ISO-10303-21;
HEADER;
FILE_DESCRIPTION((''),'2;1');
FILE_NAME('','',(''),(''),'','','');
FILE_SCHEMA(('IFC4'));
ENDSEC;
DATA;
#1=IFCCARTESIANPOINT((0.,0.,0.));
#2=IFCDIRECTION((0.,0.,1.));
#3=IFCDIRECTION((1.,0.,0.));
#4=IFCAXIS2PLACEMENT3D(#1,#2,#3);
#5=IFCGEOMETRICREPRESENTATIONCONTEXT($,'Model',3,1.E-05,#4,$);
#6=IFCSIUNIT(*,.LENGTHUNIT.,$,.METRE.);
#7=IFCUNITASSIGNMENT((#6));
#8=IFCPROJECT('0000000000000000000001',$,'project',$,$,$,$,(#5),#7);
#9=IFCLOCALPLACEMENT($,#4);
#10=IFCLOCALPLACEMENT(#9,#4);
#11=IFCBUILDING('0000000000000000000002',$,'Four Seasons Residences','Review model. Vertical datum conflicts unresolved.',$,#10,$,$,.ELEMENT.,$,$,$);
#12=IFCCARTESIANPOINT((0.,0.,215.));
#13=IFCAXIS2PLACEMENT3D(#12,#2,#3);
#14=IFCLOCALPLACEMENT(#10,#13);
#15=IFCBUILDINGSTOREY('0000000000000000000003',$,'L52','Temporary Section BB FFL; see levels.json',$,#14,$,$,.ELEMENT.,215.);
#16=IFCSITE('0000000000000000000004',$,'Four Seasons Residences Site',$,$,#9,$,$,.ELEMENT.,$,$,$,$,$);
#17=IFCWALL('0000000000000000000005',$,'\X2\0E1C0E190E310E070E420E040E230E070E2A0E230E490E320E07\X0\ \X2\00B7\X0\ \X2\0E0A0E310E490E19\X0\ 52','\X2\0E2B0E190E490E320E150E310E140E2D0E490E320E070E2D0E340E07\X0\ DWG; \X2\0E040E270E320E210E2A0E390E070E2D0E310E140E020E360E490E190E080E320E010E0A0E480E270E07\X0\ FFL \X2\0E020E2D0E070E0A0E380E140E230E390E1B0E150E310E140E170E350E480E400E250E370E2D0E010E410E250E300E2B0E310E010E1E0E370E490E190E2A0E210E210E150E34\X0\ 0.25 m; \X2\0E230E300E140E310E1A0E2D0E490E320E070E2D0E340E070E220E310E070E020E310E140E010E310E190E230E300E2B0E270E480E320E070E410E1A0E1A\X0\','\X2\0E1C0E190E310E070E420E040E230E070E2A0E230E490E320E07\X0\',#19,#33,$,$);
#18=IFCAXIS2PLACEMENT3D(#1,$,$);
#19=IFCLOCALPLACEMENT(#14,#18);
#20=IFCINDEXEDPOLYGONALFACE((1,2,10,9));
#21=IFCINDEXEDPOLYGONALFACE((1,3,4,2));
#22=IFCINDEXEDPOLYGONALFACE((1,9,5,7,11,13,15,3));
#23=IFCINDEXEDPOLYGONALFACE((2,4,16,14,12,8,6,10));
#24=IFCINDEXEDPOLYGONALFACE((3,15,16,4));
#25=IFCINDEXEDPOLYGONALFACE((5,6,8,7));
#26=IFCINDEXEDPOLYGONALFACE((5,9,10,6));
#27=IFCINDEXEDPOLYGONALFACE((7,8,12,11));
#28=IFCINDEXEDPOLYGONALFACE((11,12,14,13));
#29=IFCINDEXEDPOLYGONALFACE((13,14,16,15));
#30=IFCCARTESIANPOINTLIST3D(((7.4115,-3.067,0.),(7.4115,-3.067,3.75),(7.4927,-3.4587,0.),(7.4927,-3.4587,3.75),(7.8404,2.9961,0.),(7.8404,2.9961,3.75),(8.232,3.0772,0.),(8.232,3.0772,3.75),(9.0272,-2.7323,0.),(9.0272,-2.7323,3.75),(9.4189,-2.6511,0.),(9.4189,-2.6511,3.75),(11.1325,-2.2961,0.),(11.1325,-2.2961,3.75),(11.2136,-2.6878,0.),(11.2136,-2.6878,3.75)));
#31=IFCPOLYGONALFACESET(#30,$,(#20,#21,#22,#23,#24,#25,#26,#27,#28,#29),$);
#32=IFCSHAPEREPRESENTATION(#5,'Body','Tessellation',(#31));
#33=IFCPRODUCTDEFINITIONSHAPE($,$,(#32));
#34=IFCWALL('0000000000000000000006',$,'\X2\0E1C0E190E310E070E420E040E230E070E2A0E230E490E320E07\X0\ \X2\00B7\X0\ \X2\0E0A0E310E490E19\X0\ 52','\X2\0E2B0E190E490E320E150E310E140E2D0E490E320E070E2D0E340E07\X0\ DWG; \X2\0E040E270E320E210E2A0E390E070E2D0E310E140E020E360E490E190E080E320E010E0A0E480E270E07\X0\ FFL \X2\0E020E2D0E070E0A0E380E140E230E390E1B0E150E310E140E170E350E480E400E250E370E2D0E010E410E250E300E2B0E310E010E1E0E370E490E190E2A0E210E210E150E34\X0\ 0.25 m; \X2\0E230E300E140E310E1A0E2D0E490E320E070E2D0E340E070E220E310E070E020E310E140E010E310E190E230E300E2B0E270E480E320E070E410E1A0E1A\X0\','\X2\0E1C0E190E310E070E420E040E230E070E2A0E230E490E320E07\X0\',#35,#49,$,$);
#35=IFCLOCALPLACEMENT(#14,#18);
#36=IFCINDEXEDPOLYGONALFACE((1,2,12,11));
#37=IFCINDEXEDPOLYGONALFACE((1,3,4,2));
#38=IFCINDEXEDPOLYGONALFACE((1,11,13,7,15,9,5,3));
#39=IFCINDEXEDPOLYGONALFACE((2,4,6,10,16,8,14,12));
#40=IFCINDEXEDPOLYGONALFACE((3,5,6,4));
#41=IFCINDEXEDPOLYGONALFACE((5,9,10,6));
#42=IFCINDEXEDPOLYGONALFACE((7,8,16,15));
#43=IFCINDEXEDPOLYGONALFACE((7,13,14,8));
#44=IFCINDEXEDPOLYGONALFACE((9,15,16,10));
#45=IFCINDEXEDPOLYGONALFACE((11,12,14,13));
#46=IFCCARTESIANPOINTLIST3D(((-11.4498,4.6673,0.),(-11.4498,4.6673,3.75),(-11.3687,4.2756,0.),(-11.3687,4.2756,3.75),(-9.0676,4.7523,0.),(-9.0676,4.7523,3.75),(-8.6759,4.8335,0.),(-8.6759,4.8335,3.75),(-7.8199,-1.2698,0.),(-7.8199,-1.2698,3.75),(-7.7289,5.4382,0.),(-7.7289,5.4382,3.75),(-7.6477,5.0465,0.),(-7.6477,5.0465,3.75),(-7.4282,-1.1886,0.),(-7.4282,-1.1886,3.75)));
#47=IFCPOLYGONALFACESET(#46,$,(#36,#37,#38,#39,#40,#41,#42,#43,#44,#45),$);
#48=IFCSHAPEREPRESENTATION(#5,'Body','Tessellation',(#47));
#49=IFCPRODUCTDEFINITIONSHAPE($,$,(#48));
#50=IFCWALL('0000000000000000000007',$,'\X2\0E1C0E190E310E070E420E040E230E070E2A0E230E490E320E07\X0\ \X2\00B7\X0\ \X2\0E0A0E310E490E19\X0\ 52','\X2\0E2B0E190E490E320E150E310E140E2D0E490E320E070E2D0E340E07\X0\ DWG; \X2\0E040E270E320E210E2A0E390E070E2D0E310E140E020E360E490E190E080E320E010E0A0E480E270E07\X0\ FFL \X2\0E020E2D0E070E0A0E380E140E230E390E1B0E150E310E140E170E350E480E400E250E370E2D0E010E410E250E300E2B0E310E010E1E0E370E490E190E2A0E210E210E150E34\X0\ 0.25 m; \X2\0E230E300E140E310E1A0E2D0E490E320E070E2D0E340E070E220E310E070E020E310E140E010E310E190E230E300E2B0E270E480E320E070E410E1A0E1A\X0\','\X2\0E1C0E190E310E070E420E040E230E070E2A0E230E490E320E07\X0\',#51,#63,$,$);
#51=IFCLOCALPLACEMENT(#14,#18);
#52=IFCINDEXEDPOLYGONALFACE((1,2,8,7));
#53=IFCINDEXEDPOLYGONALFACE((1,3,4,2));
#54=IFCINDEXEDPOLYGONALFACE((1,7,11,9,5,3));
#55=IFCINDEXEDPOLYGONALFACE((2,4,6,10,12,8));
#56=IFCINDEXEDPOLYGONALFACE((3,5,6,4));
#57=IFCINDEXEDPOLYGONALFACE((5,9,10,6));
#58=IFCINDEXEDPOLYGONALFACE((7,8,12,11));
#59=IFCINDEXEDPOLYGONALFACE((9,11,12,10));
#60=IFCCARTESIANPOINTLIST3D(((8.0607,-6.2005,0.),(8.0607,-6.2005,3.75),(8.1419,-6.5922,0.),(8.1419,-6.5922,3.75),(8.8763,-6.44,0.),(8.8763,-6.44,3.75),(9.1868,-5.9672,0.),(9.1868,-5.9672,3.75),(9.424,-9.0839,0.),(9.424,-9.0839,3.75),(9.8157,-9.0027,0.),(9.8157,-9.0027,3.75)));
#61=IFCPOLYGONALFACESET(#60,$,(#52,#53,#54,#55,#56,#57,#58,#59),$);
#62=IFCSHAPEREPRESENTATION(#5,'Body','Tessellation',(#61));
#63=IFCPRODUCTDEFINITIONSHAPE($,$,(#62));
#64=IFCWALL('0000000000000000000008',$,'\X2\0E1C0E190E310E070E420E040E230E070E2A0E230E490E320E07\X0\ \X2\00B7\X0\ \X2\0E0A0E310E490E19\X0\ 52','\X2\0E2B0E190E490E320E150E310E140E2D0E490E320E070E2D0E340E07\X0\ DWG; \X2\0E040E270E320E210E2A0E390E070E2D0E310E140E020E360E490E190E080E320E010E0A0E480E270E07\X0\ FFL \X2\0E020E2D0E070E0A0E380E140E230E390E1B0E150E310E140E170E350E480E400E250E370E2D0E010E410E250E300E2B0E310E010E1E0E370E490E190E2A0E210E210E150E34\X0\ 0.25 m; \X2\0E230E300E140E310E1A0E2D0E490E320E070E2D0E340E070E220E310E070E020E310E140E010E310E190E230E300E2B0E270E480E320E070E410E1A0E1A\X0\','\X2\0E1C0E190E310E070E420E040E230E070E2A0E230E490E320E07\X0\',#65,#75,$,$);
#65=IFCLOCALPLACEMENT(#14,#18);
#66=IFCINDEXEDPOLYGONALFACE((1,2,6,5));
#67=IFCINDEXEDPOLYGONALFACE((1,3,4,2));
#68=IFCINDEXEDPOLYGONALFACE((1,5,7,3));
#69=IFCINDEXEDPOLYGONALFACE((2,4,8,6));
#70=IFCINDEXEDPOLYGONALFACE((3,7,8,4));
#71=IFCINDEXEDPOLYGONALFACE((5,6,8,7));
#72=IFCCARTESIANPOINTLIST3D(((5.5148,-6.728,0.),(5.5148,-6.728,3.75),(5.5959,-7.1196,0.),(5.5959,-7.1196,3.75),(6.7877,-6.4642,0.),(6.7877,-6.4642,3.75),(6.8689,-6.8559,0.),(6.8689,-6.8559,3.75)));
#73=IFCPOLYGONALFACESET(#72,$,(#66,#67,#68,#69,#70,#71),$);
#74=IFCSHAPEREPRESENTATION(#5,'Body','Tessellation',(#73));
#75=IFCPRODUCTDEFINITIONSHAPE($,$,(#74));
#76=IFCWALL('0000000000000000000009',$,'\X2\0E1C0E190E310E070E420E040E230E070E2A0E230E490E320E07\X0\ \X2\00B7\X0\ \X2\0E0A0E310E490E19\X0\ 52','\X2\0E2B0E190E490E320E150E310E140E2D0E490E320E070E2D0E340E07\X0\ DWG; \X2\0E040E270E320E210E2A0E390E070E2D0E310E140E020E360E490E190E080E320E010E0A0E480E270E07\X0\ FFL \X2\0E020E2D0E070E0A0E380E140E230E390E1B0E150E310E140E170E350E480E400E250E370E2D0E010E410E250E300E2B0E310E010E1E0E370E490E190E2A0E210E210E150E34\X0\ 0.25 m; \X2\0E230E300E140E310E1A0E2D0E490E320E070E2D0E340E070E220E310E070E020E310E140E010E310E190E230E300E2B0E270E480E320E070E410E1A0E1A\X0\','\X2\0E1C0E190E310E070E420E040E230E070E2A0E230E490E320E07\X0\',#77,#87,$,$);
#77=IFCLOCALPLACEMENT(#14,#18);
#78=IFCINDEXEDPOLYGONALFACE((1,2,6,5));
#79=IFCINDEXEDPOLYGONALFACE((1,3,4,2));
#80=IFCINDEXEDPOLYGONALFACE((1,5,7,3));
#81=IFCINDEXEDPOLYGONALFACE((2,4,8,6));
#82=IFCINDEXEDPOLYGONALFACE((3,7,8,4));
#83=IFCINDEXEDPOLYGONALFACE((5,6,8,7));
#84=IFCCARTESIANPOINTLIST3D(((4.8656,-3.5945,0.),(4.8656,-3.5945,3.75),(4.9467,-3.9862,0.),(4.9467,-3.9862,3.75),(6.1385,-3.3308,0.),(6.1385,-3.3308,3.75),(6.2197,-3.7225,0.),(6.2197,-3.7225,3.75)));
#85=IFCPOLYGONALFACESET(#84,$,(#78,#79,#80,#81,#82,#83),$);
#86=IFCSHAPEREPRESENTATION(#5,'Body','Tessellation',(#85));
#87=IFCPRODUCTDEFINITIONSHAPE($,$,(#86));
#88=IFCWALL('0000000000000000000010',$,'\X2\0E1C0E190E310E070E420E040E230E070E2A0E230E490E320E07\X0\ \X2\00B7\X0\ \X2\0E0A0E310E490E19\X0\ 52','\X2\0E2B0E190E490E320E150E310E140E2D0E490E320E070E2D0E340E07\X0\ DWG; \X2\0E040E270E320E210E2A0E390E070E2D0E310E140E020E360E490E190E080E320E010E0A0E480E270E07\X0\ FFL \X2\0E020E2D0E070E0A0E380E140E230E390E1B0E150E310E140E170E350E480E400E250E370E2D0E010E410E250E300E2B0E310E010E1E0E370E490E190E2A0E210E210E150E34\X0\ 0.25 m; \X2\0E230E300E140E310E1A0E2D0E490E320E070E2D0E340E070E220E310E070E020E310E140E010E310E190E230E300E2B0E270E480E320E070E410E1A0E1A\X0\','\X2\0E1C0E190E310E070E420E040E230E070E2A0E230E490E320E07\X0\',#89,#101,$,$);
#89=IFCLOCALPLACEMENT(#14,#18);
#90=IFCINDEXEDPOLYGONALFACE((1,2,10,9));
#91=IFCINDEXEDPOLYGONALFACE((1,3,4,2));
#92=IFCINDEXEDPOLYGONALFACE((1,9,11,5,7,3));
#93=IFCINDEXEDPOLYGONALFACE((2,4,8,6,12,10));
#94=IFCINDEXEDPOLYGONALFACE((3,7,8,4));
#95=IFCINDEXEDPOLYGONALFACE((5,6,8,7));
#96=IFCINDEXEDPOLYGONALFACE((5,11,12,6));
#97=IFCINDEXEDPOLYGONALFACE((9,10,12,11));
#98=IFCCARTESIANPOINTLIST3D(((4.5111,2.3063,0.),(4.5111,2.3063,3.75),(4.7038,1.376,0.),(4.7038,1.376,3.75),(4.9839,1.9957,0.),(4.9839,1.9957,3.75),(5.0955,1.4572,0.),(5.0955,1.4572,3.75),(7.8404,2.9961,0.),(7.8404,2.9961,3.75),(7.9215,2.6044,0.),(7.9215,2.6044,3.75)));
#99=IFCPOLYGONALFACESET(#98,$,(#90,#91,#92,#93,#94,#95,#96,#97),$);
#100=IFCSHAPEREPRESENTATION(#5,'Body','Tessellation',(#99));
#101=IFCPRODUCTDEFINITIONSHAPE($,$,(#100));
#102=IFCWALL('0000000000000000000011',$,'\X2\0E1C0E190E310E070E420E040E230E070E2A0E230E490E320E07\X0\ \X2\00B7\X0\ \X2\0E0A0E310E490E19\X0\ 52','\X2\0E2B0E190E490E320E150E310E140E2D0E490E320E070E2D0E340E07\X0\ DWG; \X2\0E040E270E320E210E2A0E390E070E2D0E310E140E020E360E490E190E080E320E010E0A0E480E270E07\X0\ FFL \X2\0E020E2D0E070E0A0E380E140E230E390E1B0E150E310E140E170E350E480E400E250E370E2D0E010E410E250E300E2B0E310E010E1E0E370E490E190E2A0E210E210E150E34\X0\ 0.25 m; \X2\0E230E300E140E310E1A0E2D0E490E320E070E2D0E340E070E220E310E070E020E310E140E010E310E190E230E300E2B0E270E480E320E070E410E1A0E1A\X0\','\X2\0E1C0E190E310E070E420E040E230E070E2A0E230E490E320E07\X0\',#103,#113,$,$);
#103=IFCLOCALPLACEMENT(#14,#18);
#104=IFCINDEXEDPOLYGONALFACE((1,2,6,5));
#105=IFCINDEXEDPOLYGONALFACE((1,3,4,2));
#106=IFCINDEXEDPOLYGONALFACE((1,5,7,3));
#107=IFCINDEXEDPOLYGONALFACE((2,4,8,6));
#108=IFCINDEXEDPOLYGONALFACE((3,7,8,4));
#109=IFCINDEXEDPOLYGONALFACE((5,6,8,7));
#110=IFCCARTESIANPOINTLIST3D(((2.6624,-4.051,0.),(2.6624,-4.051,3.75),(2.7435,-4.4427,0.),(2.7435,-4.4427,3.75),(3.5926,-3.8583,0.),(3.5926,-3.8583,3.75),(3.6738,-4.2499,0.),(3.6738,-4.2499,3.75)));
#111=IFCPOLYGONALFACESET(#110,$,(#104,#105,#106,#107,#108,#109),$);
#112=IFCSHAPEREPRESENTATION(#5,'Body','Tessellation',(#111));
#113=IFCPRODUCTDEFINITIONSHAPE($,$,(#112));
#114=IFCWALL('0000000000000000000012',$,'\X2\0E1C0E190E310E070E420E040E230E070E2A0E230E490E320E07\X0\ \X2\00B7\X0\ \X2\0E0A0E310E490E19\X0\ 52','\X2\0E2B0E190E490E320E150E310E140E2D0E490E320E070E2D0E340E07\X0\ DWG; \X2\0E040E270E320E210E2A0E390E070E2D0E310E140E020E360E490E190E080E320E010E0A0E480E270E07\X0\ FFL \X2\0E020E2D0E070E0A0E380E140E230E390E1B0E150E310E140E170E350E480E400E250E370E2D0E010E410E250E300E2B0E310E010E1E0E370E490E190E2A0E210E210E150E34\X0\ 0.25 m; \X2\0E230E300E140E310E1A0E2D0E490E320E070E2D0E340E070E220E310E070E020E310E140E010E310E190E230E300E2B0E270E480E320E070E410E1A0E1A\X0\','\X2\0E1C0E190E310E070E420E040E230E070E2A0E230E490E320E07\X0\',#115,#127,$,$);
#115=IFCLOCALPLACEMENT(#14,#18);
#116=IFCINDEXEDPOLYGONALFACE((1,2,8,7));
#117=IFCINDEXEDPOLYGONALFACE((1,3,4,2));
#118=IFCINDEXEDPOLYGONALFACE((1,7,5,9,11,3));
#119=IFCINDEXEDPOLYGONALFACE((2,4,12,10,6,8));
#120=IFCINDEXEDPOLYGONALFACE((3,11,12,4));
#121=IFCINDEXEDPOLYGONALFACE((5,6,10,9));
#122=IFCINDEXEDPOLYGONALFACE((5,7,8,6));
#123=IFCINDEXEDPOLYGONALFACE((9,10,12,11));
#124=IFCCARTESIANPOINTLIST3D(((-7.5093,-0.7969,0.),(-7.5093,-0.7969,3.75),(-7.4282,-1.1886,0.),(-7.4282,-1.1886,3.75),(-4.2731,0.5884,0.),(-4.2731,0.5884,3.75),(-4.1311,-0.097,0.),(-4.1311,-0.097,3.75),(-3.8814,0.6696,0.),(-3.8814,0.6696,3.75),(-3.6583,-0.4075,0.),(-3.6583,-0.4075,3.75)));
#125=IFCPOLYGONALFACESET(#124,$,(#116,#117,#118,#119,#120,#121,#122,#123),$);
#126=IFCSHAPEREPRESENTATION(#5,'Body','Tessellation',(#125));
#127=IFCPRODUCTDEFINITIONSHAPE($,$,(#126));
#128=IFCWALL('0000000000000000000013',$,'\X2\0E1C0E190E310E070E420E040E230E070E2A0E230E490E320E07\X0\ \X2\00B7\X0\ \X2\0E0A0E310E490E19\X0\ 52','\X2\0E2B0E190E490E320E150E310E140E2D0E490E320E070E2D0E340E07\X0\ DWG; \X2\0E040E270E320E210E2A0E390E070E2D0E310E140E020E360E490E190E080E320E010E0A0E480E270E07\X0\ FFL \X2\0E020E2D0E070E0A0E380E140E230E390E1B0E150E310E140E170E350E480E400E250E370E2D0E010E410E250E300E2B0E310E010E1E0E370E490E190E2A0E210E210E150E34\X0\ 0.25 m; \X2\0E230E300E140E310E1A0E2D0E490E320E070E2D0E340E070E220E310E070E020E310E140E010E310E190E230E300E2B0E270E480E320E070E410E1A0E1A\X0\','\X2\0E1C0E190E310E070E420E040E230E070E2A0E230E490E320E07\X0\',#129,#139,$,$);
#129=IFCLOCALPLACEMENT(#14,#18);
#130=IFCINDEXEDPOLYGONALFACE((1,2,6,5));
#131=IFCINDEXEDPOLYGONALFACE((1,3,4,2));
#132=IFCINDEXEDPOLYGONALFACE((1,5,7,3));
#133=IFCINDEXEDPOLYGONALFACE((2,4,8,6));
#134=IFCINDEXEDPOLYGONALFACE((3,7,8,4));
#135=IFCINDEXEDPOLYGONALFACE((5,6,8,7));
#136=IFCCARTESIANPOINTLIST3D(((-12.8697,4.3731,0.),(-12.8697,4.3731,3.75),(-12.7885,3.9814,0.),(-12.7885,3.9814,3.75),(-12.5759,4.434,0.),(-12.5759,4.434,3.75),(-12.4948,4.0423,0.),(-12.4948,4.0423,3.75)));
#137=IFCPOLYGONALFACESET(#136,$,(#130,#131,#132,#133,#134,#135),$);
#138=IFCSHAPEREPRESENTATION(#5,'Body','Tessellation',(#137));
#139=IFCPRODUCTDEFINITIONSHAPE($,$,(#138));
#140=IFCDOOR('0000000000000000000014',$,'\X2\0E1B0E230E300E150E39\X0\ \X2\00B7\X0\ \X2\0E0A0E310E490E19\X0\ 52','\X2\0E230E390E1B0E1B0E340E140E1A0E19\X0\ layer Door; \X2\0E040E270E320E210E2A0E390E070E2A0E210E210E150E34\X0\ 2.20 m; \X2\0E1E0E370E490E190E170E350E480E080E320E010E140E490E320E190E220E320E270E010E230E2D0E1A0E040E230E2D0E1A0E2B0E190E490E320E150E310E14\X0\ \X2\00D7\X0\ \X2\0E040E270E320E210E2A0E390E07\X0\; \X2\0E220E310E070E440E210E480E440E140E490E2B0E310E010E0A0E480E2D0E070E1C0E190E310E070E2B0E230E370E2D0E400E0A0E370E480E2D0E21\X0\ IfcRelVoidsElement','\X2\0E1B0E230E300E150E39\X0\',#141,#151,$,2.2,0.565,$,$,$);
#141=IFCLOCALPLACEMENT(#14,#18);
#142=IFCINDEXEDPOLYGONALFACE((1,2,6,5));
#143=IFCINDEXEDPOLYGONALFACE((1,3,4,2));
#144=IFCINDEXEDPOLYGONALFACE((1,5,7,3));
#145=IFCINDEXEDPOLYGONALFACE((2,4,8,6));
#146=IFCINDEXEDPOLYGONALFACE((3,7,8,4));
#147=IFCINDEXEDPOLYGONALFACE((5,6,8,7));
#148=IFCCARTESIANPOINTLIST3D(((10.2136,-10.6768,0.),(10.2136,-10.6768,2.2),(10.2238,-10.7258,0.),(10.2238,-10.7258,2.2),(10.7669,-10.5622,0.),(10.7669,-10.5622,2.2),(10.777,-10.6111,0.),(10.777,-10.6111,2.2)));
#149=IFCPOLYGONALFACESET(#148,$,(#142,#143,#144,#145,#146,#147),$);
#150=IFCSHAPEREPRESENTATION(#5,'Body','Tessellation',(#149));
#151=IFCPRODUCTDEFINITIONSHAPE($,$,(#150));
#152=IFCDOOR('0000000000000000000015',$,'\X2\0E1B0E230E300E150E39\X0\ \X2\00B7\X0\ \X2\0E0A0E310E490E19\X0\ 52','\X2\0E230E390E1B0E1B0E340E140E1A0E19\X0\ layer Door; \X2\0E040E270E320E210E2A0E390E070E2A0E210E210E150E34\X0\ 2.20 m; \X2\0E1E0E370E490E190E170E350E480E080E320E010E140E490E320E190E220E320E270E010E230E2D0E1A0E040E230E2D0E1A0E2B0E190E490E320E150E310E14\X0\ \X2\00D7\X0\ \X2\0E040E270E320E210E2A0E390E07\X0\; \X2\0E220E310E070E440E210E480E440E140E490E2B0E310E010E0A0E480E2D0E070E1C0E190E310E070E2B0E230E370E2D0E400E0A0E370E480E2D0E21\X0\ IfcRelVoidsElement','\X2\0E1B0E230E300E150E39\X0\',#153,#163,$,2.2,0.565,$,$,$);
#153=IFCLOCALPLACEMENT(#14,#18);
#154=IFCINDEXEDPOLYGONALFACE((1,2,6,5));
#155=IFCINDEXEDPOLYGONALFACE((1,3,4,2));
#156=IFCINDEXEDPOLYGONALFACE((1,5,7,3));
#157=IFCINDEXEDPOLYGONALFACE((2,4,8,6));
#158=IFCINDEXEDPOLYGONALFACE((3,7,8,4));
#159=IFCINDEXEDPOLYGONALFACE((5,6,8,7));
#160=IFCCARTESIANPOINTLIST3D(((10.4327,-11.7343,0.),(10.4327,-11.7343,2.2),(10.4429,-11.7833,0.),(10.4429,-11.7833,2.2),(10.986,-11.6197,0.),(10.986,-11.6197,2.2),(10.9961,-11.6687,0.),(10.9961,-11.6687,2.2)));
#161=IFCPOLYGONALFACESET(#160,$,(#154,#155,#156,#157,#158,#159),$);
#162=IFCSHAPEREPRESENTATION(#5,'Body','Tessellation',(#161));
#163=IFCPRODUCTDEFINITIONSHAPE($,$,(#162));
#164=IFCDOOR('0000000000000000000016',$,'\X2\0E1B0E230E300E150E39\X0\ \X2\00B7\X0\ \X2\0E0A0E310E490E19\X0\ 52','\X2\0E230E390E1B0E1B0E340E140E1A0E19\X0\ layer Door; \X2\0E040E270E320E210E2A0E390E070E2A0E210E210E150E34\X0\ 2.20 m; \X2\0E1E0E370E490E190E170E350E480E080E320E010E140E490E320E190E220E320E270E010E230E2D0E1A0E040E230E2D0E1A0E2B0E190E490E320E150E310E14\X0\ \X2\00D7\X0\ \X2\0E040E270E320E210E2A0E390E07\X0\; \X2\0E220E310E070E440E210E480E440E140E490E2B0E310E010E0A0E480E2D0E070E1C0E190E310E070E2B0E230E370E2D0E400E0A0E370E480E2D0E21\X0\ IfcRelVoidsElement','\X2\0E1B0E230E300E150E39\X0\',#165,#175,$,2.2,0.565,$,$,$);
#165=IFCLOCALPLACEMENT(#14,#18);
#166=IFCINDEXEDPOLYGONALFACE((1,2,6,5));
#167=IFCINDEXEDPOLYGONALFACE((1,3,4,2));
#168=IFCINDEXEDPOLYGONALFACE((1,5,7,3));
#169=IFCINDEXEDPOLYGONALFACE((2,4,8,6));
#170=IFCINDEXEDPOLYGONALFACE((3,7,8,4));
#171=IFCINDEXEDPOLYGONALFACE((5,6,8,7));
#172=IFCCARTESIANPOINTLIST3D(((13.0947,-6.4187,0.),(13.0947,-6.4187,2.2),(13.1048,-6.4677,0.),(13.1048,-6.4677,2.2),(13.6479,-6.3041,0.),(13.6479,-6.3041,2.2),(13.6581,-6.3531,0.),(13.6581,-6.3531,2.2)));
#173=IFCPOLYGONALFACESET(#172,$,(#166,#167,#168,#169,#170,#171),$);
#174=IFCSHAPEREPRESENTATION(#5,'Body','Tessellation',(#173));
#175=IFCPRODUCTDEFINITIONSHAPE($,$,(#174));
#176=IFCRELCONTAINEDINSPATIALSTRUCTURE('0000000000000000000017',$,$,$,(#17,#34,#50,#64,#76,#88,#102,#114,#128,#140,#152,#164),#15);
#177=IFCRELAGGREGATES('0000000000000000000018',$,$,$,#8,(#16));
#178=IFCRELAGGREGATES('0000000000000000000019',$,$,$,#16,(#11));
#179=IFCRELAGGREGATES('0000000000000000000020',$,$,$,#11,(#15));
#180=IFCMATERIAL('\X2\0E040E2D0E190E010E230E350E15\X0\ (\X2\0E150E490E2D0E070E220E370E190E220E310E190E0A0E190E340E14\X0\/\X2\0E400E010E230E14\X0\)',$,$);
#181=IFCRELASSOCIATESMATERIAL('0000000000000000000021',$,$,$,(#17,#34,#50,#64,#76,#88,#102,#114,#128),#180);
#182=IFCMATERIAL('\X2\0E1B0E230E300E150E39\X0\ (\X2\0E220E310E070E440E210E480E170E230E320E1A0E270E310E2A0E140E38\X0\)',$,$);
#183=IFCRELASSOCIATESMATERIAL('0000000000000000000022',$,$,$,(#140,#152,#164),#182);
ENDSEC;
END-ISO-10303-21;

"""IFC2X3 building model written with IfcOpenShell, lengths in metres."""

from ifc_helpers import new_model, si_unit, frame, origin_with_axes, place, context, project, spatial, polyline, outline, extrude, material, element, save


model = new_model("IFC2X3")

# Units and contexts
model_context = context("Model", 3, precision=1e-05, world=origin_with_axes())
ifc_project = project(units=[si_unit("LENGTHUNIT", "METRE")], contexts=[model_context])

# Site, building, storey
site_placement = place(None, origin_with_axes())
site = spatial("IfcSite", under=ifc_project, at=site_placement, Name="Four Seasons Residences Site", CompositionType="ELEMENT")
building_placement = place(site_placement, origin_with_axes())
building = spatial("IfcBuilding", under=site, at=building_placement, Name="Four Seasons Residences", Description="Review model. Vertical datum conflicts unresolved.", CompositionType="ELEMENT")
storey_placement = place(building_placement, frame((0.0, 0.0, 215.0), z_axis=(0.0, 0.0, 1.0), x_axis=(1.0, 0.0, 0.0)))
storey = spatial("IfcBuildingStorey", under=building, at=storey_placement, Name="L52", Description="Temporary Section BB FFL; see levels.json", CompositionType="ELEMENT", Elevation=215.0)

# Shared definitions
ifc_material_1 = material(Name="คอนกรีต (ต้องยืนยันชนิด/เกรด)")

# Walls
wall_1_placement = place(storey_placement, origin_with_axes())
element("IfcWall", 1, at=wall_1_placement, inside=storey, material=ifc_material_1, Name="ผนังโครงสร้าง · ชั้น 52", Description="หน้าตัดอ้างอิง DWG; ความสูงอัดขึ้นจากช่วง FFL ของชุดรูปตัดที่เลือกและหักพื้นสมมติ 0.25 m; ระดับอ้างอิงยังขัดกันระหว่างแบบ", ObjectType="ผนังโครงสร้าง", context=model_context, shape_type="SweptSolid", body=[
    extrude(outline(polyline([(7.4115, -3.067), (7.4927, -3.4587), (11.2136, -2.6878), (11.1325, -2.2961), (9.4189, -2.6511), (8.232, 3.0772), (7.8404, 2.9961), (9.0272, -2.7323), (7.4115, -3.067)])), origin_with_axes(), (0.0, 0.0, 1.0), 3.75),
])
wall_2_placement = place(storey_placement, origin_with_axes())
element("IfcWall", 2, at=wall_2_placement, inside=storey, material=ifc_material_1, Name="ผนังโครงสร้าง · ชั้น 52", Description="หน้าตัดอ้างอิง DWG; ความสูงอัดขึ้นจากช่วง FFL ของชุดรูปตัดที่เลือกและหักพื้นสมมติ 0.25 m; ระดับอ้างอิงยังขัดกันระหว่างแบบ", ObjectType="ผนังโครงสร้าง", context=model_context, shape_type="SweptSolid", body=[
    extrude(outline(polyline([(-7.4282, -1.1886), (-8.6759, 4.8335), (-7.6477, 5.0465), (-7.7289, 5.4382), (-11.4498, 4.6673), (-11.3687, 4.2756), (-9.0676, 4.7523), (-7.8199, -1.2698), (-7.4282, -1.1886)])), origin_with_axes(), (0.0, 0.0, 1.0), 3.75),
])
wall_3_placement = place(storey_placement, origin_with_axes())
element("IfcWall", 3, at=wall_3_placement, inside=storey, material=ifc_material_1, Name="ผนังโครงสร้าง · ชั้น 52", Description="หน้าตัดอ้างอิง DWG; ความสูงอัดขึ้นจากช่วง FFL ของชุดรูปตัดที่เลือกและหักพื้นสมมติ 0.25 m; ระดับอ้างอิงยังขัดกันระหว่างแบบ", ObjectType="ผนังโครงสร้าง", context=model_context, shape_type="SweptSolid", body=[
    extrude(outline(polyline([(9.8157, -9.0027), (9.1868, -5.9672), (8.0607, -6.2005), (8.1419, -6.5922), (8.8763, -6.44), (9.424, -9.0839), (9.8157, -9.0027)])), origin_with_axes(), (0.0, 0.0, 1.0), 3.75),
])
wall_4_placement = place(storey_placement, origin_with_axes())
element("IfcWall", 4, at=wall_4_placement, inside=storey, material=ifc_material_1, Name="ผนังโครงสร้าง · ชั้น 52", Description="หน้าตัดอ้างอิง DWG; ความสูงอัดขึ้นจากช่วง FFL ของชุดรูปตัดที่เลือกและหักพื้นสมมติ 0.25 m; ระดับอ้างอิงยังขัดกันระหว่างแบบ", ObjectType="ผนังโครงสร้าง", context=model_context, shape_type="SweptSolid", body=[
    extrude(outline(polyline([(6.7877, -6.4642), (6.8689, -6.8559), (5.5959, -7.1196), (5.5148, -6.728), (6.7877, -6.4642)])), origin_with_axes(), (0.0, 0.0, 1.0), 3.75),
])
wall_5_placement = place(storey_placement, origin_with_axes())
element("IfcWall", 5, at=wall_5_placement, inside=storey, material=ifc_material_1, Name="ผนังโครงสร้าง · ชั้น 52", Description="หน้าตัดอ้างอิง DWG; ความสูงอัดขึ้นจากช่วง FFL ของชุดรูปตัดที่เลือกและหักพื้นสมมติ 0.25 m; ระดับอ้างอิงยังขัดกันระหว่างแบบ", ObjectType="ผนังโครงสร้าง", context=model_context, shape_type="SweptSolid", body=[
    extrude(outline(polyline([(4.9467, -3.9862), (4.8656, -3.5945), (6.1385, -3.3308), (6.2197, -3.7225), (4.9467, -3.9862)])), origin_with_axes(), (0.0, 0.0, 1.0), 3.75),
])
wall_6_placement = place(storey_placement, origin_with_axes())
element("IfcWall", 6, at=wall_6_placement, inside=storey, material=ifc_material_1, Name="ผนังโครงสร้าง · ชั้น 52", Description="หน้าตัดอ้างอิง DWG; ความสูงอัดขึ้นจากช่วง FFL ของชุดรูปตัดที่เลือกและหักพื้นสมมติ 0.25 m; ระดับอ้างอิงยังขัดกันระหว่างแบบ", ObjectType="ผนังโครงสร้าง", context=model_context, shape_type="SweptSolid", body=[
    extrude(outline(polyline([(7.8404, 2.9961), (7.9215, 2.6044), (4.9839, 1.9957), (5.0955, 1.4572), (4.7038, 1.376), (4.5111, 2.3063), (7.8404, 2.9961)])), origin_with_axes(), (0.0, 0.0, 1.0), 3.75),
])
wall_7_placement = place(storey_placement, origin_with_axes())
element("IfcWall", 7, at=wall_7_placement, inside=storey, material=ifc_material_1, Name="ผนังโครงสร้าง · ชั้น 52", Description="หน้าตัดอ้างอิง DWG; ความสูงอัดขึ้นจากช่วง FFL ของชุดรูปตัดที่เลือกและหักพื้นสมมติ 0.25 m; ระดับอ้างอิงยังขัดกันระหว่างแบบ", ObjectType="ผนังโครงสร้าง", context=model_context, shape_type="SweptSolid", body=[
    extrude(outline(polyline([(3.5926, -3.8583), (3.6738, -4.2499), (2.7435, -4.4427), (2.6624, -4.051), (3.5926, -3.8583)])), origin_with_axes(), (0.0, 0.0, 1.0), 3.75),
])
wall_8_placement = place(storey_placement, origin_with_axes())
element("IfcWall", 8, at=wall_8_placement, inside=storey, material=ifc_material_1, Name="ผนังโครงสร้าง · ชั้น 52", Description="หน้าตัดอ้างอิง DWG; ความสูงอัดขึ้นจากช่วง FFL ของชุดรูปตัดที่เลือกและหักพื้นสมมติ 0.25 m; ระดับอ้างอิงยังขัดกันระหว่างแบบ", ObjectType="ผนังโครงสร้าง", context=model_context, shape_type="SweptSolid", body=[
    extrude(outline(polyline([(-7.4282, -1.1886), (-3.6583, -0.4075), (-3.8814, 0.6696), (-4.2731, 0.5884), (-4.1311, -0.097), (-7.5093, -0.7969), (-7.4282, -1.1886)])), origin_with_axes(), (0.0, 0.0, 1.0), 3.75),
])
wall_9_placement = place(storey_placement, origin_with_axes())
element("IfcWall", 9, at=wall_9_placement, inside=storey, material=ifc_material_1, Name="ผนังโครงสร้าง · ชั้น 52", Description="หน้าตัดอ้างอิง DWG; ความสูงอัดขึ้นจากช่วง FFL ของชุดรูปตัดที่เลือกและหักพื้นสมมติ 0.25 m; ระดับอ้างอิงยังขัดกันระหว่างแบบ", ObjectType="ผนังโครงสร้าง", context=model_context, shape_type="SweptSolid", body=[
    extrude(outline(polyline([(-12.5759, 4.434), (-12.4948, 4.0423), (-12.7885, 3.9814), (-12.8697, 4.3731), (-12.5759, 4.434)])), origin_with_axes(), (0.0, 0.0, 1.0), 3.75),
])

# Doors
ifc_material_2 = material(Name="ประตู (ยังไม่ทราบวัสดุ)")
door_1_placement = place(storey_placement, origin_with_axes())
element("IfcDoor", 10, at=door_1_placement, inside=storey, material=ifc_material_2, Name="ประตู · ชั้น 52", Description="รูปปิดบน layer Door; ความสูงสมมติ 2.20 m; พื้นที่จากด้านยาวกรอบครอบหน้าตัด × ความสูง; ยังไม่ได้หักช่องผนังหรือเชื่อม IfcRelVoidsElement", ObjectType="ประตู", OverallHeight=2.2, OverallWidth=0.565, context=model_context, shape_type="SweptSolid", body=[
    extrude(outline(polyline([(10.7669, -10.5622), (10.2136, -10.6768), (10.2238, -10.7258), (10.777, -10.6111), (10.7669, -10.5622)])), origin_with_axes(), (0.0, 0.0, 1.0), 2.2),
])
door_2_placement = place(storey_placement, origin_with_axes())
element("IfcDoor", 11, at=door_2_placement, inside=storey, material=ifc_material_2, Name="ประตู · ชั้น 52", Description="รูปปิดบน layer Door; ความสูงสมมติ 2.20 m; พื้นที่จากด้านยาวกรอบครอบหน้าตัด × ความสูง; ยังไม่ได้หักช่องผนังหรือเชื่อม IfcRelVoidsElement", ObjectType="ประตู", OverallHeight=2.2, OverallWidth=0.565, context=model_context, shape_type="SweptSolid", body=[
    extrude(outline(polyline([(10.9961, -11.6687), (10.4429, -11.7833), (10.4327, -11.7343), (10.986, -11.6197), (10.9961, -11.6687)])), origin_with_axes(), (0.0, 0.0, 1.0), 2.2),
])
door_3_placement = place(storey_placement, origin_with_axes())
element("IfcDoor", 12, at=door_3_placement, inside=storey, material=ifc_material_2, Name="ประตู · ชั้น 52", Description="รูปปิดบน layer Door; ความสูงสมมติ 2.20 m; พื้นที่จากด้านยาวกรอบครอบหน้าตัด × ความสูง; ยังไม่ได้หักช่องผนังหรือเชื่อม IfcRelVoidsElement", ObjectType="ประตู", OverallHeight=2.2, OverallWidth=0.565, context=model_context, shape_type="SweptSolid", body=[
    extrude(outline(polyline([(13.0947, -6.4187), (13.6479, -6.3041), (13.6581, -6.3531), (13.1048, -6.4677), (13.0947, -6.4187)])), origin_with_axes(), (0.0, 0.0, 1.0), 2.2),
])

save(model, "model.ifc")
